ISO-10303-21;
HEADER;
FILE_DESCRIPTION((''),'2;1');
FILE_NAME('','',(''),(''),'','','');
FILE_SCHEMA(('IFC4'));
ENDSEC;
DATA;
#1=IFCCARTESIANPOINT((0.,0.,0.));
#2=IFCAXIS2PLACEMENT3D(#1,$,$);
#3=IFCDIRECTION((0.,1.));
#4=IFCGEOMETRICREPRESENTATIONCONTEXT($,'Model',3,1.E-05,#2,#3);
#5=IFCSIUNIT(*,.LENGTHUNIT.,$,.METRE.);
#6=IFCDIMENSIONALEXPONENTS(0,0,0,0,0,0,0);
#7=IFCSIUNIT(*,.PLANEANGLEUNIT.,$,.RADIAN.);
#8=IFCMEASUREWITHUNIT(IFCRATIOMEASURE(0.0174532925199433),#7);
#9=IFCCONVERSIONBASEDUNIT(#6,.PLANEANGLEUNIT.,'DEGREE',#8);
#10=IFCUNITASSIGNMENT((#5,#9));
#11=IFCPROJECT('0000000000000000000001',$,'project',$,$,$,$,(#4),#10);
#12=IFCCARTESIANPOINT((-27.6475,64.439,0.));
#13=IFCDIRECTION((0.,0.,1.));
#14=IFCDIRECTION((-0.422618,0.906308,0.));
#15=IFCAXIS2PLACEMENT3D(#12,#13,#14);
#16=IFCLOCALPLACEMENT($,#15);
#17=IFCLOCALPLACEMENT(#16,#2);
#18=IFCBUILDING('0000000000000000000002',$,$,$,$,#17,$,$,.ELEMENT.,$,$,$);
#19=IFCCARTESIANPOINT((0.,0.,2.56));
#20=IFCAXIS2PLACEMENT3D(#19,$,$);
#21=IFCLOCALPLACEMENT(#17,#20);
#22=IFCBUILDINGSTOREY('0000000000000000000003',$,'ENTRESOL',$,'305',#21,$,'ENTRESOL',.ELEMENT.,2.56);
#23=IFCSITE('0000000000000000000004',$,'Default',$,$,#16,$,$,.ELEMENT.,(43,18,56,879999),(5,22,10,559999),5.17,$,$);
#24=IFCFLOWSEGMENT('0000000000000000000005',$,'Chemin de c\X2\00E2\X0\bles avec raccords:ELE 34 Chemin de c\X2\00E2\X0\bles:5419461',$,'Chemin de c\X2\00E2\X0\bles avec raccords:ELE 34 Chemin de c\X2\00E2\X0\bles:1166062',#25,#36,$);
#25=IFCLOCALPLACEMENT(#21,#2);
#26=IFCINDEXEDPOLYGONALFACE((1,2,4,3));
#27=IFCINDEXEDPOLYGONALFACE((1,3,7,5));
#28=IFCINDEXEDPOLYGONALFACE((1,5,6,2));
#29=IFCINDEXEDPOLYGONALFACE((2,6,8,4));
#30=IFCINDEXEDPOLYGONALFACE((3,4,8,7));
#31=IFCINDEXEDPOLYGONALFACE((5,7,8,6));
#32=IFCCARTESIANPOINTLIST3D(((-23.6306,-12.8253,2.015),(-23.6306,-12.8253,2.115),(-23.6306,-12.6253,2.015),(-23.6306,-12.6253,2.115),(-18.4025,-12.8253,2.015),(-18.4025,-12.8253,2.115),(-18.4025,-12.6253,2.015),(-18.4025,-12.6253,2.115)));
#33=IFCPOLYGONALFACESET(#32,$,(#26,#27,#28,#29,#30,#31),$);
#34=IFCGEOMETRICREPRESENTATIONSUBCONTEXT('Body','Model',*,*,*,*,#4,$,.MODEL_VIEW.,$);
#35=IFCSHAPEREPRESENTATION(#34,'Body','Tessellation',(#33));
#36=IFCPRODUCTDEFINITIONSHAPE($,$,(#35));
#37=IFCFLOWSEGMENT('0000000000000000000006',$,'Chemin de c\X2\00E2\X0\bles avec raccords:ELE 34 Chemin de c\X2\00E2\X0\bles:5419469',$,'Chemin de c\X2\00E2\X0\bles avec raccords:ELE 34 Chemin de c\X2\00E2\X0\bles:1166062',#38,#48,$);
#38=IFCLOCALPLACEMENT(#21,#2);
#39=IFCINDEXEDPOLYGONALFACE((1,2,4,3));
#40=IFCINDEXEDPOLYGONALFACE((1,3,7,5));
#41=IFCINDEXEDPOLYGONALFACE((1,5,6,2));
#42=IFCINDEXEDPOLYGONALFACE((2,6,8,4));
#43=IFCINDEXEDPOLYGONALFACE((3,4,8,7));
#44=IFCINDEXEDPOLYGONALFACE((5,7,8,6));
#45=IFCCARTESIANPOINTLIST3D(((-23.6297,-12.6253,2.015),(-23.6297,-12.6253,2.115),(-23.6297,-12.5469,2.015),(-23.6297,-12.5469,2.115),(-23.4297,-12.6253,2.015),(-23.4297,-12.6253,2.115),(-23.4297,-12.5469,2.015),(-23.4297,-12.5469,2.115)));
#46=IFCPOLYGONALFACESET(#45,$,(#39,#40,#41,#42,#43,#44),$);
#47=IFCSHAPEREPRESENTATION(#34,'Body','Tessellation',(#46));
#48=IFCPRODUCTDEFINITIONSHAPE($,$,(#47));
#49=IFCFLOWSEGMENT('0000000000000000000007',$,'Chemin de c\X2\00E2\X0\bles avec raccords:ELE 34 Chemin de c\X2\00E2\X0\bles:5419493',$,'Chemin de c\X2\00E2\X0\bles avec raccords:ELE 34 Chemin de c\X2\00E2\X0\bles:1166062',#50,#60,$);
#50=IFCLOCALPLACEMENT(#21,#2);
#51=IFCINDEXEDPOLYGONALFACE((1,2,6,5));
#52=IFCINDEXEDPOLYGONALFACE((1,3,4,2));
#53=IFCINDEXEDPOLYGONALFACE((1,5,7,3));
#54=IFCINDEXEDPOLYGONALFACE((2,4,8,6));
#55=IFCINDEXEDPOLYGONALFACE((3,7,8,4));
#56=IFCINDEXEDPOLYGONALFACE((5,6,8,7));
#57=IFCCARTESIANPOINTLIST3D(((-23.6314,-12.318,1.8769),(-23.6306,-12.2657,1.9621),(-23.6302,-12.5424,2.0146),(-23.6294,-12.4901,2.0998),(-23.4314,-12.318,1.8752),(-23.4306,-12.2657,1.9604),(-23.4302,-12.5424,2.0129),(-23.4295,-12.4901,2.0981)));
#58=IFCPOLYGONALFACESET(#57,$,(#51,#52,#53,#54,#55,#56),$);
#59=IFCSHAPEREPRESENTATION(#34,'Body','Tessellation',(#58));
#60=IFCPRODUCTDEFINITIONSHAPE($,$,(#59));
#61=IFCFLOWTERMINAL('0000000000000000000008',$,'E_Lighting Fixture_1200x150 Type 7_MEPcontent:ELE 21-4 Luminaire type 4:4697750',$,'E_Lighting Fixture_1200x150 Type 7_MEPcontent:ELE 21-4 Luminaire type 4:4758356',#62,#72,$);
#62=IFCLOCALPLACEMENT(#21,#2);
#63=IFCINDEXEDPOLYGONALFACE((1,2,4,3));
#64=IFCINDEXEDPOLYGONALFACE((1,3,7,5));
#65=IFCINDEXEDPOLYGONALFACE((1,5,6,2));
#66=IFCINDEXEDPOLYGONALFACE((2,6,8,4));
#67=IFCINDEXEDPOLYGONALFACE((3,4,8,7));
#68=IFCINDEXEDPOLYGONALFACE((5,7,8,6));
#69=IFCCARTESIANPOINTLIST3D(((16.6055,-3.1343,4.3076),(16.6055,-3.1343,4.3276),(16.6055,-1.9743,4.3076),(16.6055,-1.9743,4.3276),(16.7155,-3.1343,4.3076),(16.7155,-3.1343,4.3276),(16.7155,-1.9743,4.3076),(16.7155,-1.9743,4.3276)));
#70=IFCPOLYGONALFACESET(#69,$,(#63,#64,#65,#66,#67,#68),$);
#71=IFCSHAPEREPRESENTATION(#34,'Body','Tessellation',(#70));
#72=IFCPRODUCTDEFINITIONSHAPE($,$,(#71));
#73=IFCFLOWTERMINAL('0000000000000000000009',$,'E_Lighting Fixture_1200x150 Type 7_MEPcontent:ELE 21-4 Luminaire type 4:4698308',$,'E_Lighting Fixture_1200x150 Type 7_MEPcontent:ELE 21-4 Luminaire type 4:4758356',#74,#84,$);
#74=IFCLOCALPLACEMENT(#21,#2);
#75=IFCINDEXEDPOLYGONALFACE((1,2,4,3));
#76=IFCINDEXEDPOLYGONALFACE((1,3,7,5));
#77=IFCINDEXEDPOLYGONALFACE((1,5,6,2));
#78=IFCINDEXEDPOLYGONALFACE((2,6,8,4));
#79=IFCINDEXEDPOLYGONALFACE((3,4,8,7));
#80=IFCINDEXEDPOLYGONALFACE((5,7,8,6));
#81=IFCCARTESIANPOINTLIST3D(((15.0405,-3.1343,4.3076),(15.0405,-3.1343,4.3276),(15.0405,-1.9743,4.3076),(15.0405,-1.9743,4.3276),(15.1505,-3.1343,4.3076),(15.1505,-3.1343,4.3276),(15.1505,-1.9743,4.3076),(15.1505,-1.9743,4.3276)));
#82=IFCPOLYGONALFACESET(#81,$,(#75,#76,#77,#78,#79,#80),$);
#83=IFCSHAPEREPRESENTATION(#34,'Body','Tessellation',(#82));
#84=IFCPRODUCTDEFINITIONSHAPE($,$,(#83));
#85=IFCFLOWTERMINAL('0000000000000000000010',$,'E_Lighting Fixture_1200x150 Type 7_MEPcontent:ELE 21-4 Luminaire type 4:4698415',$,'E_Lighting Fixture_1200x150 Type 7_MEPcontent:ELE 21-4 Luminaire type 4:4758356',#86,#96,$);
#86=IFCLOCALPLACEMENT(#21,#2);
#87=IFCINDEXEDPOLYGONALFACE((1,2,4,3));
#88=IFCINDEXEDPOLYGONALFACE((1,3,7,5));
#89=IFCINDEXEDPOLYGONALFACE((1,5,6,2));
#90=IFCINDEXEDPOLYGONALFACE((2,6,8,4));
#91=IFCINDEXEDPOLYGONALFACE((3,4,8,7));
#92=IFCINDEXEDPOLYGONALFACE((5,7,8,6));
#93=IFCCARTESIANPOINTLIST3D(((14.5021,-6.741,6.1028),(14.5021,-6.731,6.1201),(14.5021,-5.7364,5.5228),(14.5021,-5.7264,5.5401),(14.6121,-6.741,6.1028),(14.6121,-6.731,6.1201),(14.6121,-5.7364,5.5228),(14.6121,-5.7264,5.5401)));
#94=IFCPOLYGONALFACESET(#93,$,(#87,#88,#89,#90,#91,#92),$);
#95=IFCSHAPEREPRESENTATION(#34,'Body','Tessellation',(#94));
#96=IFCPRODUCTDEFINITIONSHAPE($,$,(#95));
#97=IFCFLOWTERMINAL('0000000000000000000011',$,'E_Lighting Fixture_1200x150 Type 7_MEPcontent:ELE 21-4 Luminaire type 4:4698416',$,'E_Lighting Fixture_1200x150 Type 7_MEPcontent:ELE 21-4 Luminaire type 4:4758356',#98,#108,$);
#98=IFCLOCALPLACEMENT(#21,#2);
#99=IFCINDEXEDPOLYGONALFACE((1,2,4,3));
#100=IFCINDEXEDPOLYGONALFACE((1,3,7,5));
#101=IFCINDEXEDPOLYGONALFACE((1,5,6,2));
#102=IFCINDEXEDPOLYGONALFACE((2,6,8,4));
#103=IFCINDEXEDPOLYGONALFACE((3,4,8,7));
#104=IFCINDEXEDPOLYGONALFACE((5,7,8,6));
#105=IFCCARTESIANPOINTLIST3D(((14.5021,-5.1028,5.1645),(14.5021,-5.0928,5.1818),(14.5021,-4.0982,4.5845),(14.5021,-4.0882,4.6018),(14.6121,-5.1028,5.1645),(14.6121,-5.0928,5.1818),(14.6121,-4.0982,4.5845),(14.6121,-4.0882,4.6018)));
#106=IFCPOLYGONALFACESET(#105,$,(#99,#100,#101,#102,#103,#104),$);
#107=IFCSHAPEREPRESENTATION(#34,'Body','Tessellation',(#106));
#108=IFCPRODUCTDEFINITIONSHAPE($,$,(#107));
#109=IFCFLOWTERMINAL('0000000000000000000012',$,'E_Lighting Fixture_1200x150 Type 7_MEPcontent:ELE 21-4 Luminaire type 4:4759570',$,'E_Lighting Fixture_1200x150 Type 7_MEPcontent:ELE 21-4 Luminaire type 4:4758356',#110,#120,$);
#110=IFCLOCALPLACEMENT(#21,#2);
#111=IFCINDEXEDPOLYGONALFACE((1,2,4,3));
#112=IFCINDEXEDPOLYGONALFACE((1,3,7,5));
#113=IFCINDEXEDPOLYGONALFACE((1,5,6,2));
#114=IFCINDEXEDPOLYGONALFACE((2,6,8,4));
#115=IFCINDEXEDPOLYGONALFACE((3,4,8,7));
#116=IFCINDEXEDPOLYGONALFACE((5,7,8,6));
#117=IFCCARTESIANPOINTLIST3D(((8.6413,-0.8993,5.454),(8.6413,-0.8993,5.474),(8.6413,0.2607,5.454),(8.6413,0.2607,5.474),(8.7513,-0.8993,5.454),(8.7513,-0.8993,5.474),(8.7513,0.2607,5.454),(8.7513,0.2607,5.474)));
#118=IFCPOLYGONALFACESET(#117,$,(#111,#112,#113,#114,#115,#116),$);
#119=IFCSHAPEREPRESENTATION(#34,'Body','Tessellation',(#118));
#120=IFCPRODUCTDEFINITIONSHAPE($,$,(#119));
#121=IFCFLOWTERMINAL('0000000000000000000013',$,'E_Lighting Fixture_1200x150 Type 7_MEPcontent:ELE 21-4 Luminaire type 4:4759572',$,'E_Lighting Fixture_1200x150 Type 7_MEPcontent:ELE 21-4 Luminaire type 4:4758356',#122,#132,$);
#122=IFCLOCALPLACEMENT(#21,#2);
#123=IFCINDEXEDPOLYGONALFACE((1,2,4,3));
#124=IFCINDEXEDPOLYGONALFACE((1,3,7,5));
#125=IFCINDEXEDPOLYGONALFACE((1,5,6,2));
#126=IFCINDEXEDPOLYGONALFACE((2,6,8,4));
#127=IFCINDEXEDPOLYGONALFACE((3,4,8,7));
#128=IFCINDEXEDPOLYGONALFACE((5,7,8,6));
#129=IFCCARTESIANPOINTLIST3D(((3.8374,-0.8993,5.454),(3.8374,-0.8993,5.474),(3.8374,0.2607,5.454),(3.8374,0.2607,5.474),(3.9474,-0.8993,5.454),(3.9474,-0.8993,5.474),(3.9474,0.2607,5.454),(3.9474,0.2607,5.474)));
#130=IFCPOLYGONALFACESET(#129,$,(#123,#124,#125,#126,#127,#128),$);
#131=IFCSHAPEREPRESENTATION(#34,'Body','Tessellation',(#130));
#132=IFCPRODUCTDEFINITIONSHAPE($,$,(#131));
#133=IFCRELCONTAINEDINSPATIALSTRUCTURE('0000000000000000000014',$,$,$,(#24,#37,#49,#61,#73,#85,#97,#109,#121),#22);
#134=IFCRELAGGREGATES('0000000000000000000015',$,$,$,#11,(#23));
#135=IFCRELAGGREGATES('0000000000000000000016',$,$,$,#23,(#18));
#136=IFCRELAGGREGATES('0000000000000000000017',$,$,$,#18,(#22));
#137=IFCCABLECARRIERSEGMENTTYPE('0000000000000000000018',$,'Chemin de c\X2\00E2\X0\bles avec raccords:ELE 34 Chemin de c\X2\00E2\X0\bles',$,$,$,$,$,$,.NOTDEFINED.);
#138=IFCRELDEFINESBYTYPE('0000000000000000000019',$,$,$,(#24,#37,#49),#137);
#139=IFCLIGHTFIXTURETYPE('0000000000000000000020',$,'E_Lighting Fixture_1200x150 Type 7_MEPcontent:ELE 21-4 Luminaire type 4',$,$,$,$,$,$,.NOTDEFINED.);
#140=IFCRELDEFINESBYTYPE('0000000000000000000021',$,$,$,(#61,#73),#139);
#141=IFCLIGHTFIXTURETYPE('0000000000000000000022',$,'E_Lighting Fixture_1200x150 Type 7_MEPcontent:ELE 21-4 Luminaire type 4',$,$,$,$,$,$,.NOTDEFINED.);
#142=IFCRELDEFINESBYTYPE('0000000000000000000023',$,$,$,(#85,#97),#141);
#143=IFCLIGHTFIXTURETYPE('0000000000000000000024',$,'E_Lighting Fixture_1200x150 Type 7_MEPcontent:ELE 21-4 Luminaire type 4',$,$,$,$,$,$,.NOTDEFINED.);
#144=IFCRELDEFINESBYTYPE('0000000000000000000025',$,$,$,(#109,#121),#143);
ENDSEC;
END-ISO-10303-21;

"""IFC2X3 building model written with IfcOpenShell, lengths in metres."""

from ifc_helpers import new_model, entity, si_unit, converted_unit, direction, frame, frame_2d, origin, origin_2d_with_axis, place, context, subcontext, project, spatial, rectangle, extrude, source, transform, mapped, type_object, type_shapes, element, save


model = new_model("IFC2X3")

# Units and contexts
model_context = context("Model", 3, precision=1e-05, world=origin(), true_north=direction((0.0, 1.0)))
body_context = subcontext(model_context, "Body", "Model", "MODEL_VIEW")
ifc_project = project(units=[si_unit("LENGTHUNIT", "METRE"), converted_unit("PLANEANGLEUNIT", "DEGREE", entity("IfcRatioMeasure", 0.0174532925199433), si_unit("PLANEANGLEUNIT", "RADIAN"), dimensions=[0, 0, 0, 0, 0, 0, 0])], contexts=[model_context])

# Site, building, storey
site_placement = place(None, frame((-27.6475, 64.439, 0.0), z_axis=(0.0, 0.0, 1.0), x_axis=(-0.422618, 0.906308, 0.0)))
site = spatial("IfcSite", under=ifc_project, at=site_placement, Name="Default", CompositionType="ELEMENT", RefLatitude=(43, 18, 56, 879999), RefLongitude=(5, 22, 10, 559999), RefElevation=5.17)
building_placement = place(site_placement, origin())
building = spatial("IfcBuilding", under=site, at=building_placement, CompositionType="ELEMENT")
storey_placement = place(building_placement, frame((0.0, 0.0, 2.56)))
storey = spatial("IfcBuildingStorey", under=building, at=storey_placement, Name="ENTRESOL", ObjectType="305", LongName="ENTRESOL", CompositionType="ELEMENT", Elevation=2.56)

# Flow segments
cable_carrier_segment_type = type_object("IfcCableCarrierSegmentType", Name="Chemin de câbles avec raccords:ELE 34 Chemin de câbles", PredefinedType="NOTDEFINED")
flow_segment_1_placement = place(storey_placement, origin())
element("IfcFlowSegment", 1, at=flow_segment_1_placement, inside=storey, type_object=cable_carrier_segment_type, Name="Chemin de câbles avec raccords:ELE 34 Chemin de câbles:5419461", ObjectType="Chemin de câbles avec raccords:ELE 34 Chemin de câbles:1166062", context=body_context, shape_type="SweptSolid", body=[
    extrude(rectangle(XDim=5.2281, YDim=0.2, at=frame_2d((0.0, 0.0), x_axis=(1.0, 0.0))), frame((-21.0165, -12.7253, 2.015), z_axis=(-0.000002, 0.0, 1.0), x_axis=(-1.0, 0.0, -0.000002)), (0.0, 0.0, 1.0), 0.1),
])
flow_segment_2_placement = place(storey_placement, origin())
element("IfcFlowSegment", 2, at=flow_segment_2_placement, inside=storey, type_object=cable_carrier_segment_type, Name="Chemin de câbles avec raccords:ELE 34 Chemin de câbles:5419469", ObjectType="Chemin de câbles avec raccords:ELE 34 Chemin de câbles:1166062", context=body_context, shape_type="SweptSolid", body=[
    extrude(rectangle(XDim=0.0784, YDim=0.2, at=frame_2d((0.0, 0.0), x_axis=(1.0, 0.0))), frame((-23.5297, -12.5861, 2.015), z_axis=(0.0, 0.0, 1.0), x_axis=(0.0, -1.0, 0.0)), (0.0, 0.0, 1.0), 0.1),
])
flow_segment_3_placement = place(storey_placement, origin())
element("IfcFlowSegment", 3, at=flow_segment_3_placement, inside=storey, type_object=cable_carrier_segment_type, Name="Chemin de câbles avec raccords:ELE 34 Chemin de câbles:5419493", ObjectType="Chemin de câbles avec raccords:ELE 34 Chemin de câbles:1166062", context=body_context, shape_type="SweptSolid", body=[
    extrude(rectangle(XDim=0.1, YDim=0.2, at=frame_2d((0.0, 0.0), x_axis=(1.0, 0.0))), frame((-23.5298, -12.5162, 2.0563), z_axis=(-0.004522, 0.852361, -0.522935), x_axis=(0.007371, 0.522954, 0.852329)), (0.0, 0.0, 1.0), 0.2633),
])

# Flow terminals
light_fixture_type_1 = type_object("IfcLightFixtureType", Name="E_Lighting Fixture_1200x150 Type 7_MEPcontent:ELE 21-4 Luminaire type 4", PredefinedType="NOTDEFINED")
shared_shape_1 = source(origin(), body_context, "Body", "SweptSolid", [
    extrude(rectangle(XDim=1.16, YDim=0.11, at=origin_2d_with_axis()), frame((0.0, 0.0, -0.02)), (0.0, 0.0, 1.0), 0.02),
])
type_shapes(light_fixture_type_1, [shared_shape_1])
for number, where, z_axis, x_axis, name in (
    (4, (16.6605, -2.5543, 4.3276), (0.0, 0.0, 1.0), (0.0, -1.0, 0.0), "E_Lighting Fixture_1200x150 Type 7_MEPcontent:ELE 21-4 Luminaire type 4:4697750"),
    (5, (15.0955, -2.5543, 4.3276), (0.0, 0.0, 1.0), (0.0, -1.0, 0.0), "E_Lighting Fixture_1200x150 Type 7_MEPcontent:ELE 21-4 Luminaire type 4:4698308"),
):
    element("IfcFlowTerminal", number, at=place(storey_placement, frame(where, z_axis=z_axis, x_axis=x_axis)), inside=storey, type_object=light_fixture_type_1, Name=name, ObjectType="E_Lighting Fixture_1200x150 Type 7_MEPcontent:ELE 21-4 Luminaire type 4:4758356", context=body_context, shape_type="MappedRepresentation", body=[
        mapped(shared_shape_1, transform((0.0, 0.0, 0.0), scale=1.0)),
    ])
light_fixture_type_2 = type_object("IfcLightFixtureType", Name="E_Lighting Fixture_1200x150 Type 7_MEPcontent:ELE 21-4 Luminaire type 4", PredefinedType="NOTDEFINED")
shared_shape_2 = source(origin(), body_context, "Body", "SweptSolid", [
    extrude(rectangle(XDim=0.02, YDim=0.11, at=frame_2d((0.0, 0.0), x_axis=(1.0, 0.0))), frame((-0.5073, 0.0, -0.2813), z_axis=(0.866025, 0.0, 0.5), x_axis=(0.5, 0.0, -0.866025)), (0.0, 0.0, 1.0), 1.16),
])
type_shapes(light_fixture_type_2, [shared_shape_2])
for number, where, z_axis, x_axis, name in (
    (6, (14.5571, -6.2387, 5.8128), (0.0, 0.0, 1.0), (0.0, -1.0, 0.0), "E_Lighting Fixture_1200x150 Type 7_MEPcontent:ELE 21-4 Luminaire type 4:4698415"),
    (7, (14.5571, -4.6005, 4.8745), (0.0, 0.0, 1.0), (0.0, -1.0, 0.0), "E_Lighting Fixture_1200x150 Type 7_MEPcontent:ELE 21-4 Luminaire type 4:4698416"),
):
    element("IfcFlowTerminal", number, at=place(storey_placement, frame(where, z_axis=z_axis, x_axis=x_axis)), inside=storey, type_object=light_fixture_type_2, Name=name, ObjectType="E_Lighting Fixture_1200x150 Type 7_MEPcontent:ELE 21-4 Luminaire type 4:4758356", context=body_context, shape_type="MappedRepresentation", body=[
        mapped(shared_shape_2, transform((0.0, 0.0, 0.0), scale=1.0)),
    ])
light_fixture_type_3 = type_object("IfcLightFixtureType", Name="E_Lighting Fixture_1200x150 Type 7_MEPcontent:ELE 21-4 Luminaire type 4", PredefinedType="NOTDEFINED")
shared_shape_3 = source(origin(), body_context, "Body", "SweptSolid", [
    extrude(rectangle(XDim=0.11, YDim=1.16, at=origin_2d_with_axis()), frame((0.0, 0.0, 0.0), z_axis=(0.0, 0.0, 1.0), x_axis=(0.0, -1.0, 0.0)), (0.0, 0.0, 1.0), 0.02),
])
type_shapes(light_fixture_type_3, [shared_shape_3])
for number, where, z_axis, x_axis, name in (
    (8, (8.6963, -0.3193, 5.454), (0.0, 0.0, 1.0), (0.0, -1.0, 0.0), "E_Lighting Fixture_1200x150 Type 7_MEPcontent:ELE 21-4 Luminaire type 4:4759570"),
    (9, (3.8924, -0.3193, 5.454), (0.0, 0.0, 1.0), (0.0, -1.0, 0.0), "E_Lighting Fixture_1200x150 Type 7_MEPcontent:ELE 21-4 Luminaire type 4:4759572"),
):
    element("IfcFlowTerminal", number, at=place(storey_placement, frame(where, z_axis=z_axis, x_axis=x_axis)), inside=storey, type_object=light_fixture_type_3, Name=name, ObjectType="E_Lighting Fixture_1200x150 Type 7_MEPcontent:ELE 21-4 Luminaire type 4:4758356", context=body_context, shape_type="MappedRepresentation", body=[
        mapped(shared_shape_3, transform((0.0, 0.0, 0.0), scale=1.0)),
    ])

save(model, "model.ifc")
